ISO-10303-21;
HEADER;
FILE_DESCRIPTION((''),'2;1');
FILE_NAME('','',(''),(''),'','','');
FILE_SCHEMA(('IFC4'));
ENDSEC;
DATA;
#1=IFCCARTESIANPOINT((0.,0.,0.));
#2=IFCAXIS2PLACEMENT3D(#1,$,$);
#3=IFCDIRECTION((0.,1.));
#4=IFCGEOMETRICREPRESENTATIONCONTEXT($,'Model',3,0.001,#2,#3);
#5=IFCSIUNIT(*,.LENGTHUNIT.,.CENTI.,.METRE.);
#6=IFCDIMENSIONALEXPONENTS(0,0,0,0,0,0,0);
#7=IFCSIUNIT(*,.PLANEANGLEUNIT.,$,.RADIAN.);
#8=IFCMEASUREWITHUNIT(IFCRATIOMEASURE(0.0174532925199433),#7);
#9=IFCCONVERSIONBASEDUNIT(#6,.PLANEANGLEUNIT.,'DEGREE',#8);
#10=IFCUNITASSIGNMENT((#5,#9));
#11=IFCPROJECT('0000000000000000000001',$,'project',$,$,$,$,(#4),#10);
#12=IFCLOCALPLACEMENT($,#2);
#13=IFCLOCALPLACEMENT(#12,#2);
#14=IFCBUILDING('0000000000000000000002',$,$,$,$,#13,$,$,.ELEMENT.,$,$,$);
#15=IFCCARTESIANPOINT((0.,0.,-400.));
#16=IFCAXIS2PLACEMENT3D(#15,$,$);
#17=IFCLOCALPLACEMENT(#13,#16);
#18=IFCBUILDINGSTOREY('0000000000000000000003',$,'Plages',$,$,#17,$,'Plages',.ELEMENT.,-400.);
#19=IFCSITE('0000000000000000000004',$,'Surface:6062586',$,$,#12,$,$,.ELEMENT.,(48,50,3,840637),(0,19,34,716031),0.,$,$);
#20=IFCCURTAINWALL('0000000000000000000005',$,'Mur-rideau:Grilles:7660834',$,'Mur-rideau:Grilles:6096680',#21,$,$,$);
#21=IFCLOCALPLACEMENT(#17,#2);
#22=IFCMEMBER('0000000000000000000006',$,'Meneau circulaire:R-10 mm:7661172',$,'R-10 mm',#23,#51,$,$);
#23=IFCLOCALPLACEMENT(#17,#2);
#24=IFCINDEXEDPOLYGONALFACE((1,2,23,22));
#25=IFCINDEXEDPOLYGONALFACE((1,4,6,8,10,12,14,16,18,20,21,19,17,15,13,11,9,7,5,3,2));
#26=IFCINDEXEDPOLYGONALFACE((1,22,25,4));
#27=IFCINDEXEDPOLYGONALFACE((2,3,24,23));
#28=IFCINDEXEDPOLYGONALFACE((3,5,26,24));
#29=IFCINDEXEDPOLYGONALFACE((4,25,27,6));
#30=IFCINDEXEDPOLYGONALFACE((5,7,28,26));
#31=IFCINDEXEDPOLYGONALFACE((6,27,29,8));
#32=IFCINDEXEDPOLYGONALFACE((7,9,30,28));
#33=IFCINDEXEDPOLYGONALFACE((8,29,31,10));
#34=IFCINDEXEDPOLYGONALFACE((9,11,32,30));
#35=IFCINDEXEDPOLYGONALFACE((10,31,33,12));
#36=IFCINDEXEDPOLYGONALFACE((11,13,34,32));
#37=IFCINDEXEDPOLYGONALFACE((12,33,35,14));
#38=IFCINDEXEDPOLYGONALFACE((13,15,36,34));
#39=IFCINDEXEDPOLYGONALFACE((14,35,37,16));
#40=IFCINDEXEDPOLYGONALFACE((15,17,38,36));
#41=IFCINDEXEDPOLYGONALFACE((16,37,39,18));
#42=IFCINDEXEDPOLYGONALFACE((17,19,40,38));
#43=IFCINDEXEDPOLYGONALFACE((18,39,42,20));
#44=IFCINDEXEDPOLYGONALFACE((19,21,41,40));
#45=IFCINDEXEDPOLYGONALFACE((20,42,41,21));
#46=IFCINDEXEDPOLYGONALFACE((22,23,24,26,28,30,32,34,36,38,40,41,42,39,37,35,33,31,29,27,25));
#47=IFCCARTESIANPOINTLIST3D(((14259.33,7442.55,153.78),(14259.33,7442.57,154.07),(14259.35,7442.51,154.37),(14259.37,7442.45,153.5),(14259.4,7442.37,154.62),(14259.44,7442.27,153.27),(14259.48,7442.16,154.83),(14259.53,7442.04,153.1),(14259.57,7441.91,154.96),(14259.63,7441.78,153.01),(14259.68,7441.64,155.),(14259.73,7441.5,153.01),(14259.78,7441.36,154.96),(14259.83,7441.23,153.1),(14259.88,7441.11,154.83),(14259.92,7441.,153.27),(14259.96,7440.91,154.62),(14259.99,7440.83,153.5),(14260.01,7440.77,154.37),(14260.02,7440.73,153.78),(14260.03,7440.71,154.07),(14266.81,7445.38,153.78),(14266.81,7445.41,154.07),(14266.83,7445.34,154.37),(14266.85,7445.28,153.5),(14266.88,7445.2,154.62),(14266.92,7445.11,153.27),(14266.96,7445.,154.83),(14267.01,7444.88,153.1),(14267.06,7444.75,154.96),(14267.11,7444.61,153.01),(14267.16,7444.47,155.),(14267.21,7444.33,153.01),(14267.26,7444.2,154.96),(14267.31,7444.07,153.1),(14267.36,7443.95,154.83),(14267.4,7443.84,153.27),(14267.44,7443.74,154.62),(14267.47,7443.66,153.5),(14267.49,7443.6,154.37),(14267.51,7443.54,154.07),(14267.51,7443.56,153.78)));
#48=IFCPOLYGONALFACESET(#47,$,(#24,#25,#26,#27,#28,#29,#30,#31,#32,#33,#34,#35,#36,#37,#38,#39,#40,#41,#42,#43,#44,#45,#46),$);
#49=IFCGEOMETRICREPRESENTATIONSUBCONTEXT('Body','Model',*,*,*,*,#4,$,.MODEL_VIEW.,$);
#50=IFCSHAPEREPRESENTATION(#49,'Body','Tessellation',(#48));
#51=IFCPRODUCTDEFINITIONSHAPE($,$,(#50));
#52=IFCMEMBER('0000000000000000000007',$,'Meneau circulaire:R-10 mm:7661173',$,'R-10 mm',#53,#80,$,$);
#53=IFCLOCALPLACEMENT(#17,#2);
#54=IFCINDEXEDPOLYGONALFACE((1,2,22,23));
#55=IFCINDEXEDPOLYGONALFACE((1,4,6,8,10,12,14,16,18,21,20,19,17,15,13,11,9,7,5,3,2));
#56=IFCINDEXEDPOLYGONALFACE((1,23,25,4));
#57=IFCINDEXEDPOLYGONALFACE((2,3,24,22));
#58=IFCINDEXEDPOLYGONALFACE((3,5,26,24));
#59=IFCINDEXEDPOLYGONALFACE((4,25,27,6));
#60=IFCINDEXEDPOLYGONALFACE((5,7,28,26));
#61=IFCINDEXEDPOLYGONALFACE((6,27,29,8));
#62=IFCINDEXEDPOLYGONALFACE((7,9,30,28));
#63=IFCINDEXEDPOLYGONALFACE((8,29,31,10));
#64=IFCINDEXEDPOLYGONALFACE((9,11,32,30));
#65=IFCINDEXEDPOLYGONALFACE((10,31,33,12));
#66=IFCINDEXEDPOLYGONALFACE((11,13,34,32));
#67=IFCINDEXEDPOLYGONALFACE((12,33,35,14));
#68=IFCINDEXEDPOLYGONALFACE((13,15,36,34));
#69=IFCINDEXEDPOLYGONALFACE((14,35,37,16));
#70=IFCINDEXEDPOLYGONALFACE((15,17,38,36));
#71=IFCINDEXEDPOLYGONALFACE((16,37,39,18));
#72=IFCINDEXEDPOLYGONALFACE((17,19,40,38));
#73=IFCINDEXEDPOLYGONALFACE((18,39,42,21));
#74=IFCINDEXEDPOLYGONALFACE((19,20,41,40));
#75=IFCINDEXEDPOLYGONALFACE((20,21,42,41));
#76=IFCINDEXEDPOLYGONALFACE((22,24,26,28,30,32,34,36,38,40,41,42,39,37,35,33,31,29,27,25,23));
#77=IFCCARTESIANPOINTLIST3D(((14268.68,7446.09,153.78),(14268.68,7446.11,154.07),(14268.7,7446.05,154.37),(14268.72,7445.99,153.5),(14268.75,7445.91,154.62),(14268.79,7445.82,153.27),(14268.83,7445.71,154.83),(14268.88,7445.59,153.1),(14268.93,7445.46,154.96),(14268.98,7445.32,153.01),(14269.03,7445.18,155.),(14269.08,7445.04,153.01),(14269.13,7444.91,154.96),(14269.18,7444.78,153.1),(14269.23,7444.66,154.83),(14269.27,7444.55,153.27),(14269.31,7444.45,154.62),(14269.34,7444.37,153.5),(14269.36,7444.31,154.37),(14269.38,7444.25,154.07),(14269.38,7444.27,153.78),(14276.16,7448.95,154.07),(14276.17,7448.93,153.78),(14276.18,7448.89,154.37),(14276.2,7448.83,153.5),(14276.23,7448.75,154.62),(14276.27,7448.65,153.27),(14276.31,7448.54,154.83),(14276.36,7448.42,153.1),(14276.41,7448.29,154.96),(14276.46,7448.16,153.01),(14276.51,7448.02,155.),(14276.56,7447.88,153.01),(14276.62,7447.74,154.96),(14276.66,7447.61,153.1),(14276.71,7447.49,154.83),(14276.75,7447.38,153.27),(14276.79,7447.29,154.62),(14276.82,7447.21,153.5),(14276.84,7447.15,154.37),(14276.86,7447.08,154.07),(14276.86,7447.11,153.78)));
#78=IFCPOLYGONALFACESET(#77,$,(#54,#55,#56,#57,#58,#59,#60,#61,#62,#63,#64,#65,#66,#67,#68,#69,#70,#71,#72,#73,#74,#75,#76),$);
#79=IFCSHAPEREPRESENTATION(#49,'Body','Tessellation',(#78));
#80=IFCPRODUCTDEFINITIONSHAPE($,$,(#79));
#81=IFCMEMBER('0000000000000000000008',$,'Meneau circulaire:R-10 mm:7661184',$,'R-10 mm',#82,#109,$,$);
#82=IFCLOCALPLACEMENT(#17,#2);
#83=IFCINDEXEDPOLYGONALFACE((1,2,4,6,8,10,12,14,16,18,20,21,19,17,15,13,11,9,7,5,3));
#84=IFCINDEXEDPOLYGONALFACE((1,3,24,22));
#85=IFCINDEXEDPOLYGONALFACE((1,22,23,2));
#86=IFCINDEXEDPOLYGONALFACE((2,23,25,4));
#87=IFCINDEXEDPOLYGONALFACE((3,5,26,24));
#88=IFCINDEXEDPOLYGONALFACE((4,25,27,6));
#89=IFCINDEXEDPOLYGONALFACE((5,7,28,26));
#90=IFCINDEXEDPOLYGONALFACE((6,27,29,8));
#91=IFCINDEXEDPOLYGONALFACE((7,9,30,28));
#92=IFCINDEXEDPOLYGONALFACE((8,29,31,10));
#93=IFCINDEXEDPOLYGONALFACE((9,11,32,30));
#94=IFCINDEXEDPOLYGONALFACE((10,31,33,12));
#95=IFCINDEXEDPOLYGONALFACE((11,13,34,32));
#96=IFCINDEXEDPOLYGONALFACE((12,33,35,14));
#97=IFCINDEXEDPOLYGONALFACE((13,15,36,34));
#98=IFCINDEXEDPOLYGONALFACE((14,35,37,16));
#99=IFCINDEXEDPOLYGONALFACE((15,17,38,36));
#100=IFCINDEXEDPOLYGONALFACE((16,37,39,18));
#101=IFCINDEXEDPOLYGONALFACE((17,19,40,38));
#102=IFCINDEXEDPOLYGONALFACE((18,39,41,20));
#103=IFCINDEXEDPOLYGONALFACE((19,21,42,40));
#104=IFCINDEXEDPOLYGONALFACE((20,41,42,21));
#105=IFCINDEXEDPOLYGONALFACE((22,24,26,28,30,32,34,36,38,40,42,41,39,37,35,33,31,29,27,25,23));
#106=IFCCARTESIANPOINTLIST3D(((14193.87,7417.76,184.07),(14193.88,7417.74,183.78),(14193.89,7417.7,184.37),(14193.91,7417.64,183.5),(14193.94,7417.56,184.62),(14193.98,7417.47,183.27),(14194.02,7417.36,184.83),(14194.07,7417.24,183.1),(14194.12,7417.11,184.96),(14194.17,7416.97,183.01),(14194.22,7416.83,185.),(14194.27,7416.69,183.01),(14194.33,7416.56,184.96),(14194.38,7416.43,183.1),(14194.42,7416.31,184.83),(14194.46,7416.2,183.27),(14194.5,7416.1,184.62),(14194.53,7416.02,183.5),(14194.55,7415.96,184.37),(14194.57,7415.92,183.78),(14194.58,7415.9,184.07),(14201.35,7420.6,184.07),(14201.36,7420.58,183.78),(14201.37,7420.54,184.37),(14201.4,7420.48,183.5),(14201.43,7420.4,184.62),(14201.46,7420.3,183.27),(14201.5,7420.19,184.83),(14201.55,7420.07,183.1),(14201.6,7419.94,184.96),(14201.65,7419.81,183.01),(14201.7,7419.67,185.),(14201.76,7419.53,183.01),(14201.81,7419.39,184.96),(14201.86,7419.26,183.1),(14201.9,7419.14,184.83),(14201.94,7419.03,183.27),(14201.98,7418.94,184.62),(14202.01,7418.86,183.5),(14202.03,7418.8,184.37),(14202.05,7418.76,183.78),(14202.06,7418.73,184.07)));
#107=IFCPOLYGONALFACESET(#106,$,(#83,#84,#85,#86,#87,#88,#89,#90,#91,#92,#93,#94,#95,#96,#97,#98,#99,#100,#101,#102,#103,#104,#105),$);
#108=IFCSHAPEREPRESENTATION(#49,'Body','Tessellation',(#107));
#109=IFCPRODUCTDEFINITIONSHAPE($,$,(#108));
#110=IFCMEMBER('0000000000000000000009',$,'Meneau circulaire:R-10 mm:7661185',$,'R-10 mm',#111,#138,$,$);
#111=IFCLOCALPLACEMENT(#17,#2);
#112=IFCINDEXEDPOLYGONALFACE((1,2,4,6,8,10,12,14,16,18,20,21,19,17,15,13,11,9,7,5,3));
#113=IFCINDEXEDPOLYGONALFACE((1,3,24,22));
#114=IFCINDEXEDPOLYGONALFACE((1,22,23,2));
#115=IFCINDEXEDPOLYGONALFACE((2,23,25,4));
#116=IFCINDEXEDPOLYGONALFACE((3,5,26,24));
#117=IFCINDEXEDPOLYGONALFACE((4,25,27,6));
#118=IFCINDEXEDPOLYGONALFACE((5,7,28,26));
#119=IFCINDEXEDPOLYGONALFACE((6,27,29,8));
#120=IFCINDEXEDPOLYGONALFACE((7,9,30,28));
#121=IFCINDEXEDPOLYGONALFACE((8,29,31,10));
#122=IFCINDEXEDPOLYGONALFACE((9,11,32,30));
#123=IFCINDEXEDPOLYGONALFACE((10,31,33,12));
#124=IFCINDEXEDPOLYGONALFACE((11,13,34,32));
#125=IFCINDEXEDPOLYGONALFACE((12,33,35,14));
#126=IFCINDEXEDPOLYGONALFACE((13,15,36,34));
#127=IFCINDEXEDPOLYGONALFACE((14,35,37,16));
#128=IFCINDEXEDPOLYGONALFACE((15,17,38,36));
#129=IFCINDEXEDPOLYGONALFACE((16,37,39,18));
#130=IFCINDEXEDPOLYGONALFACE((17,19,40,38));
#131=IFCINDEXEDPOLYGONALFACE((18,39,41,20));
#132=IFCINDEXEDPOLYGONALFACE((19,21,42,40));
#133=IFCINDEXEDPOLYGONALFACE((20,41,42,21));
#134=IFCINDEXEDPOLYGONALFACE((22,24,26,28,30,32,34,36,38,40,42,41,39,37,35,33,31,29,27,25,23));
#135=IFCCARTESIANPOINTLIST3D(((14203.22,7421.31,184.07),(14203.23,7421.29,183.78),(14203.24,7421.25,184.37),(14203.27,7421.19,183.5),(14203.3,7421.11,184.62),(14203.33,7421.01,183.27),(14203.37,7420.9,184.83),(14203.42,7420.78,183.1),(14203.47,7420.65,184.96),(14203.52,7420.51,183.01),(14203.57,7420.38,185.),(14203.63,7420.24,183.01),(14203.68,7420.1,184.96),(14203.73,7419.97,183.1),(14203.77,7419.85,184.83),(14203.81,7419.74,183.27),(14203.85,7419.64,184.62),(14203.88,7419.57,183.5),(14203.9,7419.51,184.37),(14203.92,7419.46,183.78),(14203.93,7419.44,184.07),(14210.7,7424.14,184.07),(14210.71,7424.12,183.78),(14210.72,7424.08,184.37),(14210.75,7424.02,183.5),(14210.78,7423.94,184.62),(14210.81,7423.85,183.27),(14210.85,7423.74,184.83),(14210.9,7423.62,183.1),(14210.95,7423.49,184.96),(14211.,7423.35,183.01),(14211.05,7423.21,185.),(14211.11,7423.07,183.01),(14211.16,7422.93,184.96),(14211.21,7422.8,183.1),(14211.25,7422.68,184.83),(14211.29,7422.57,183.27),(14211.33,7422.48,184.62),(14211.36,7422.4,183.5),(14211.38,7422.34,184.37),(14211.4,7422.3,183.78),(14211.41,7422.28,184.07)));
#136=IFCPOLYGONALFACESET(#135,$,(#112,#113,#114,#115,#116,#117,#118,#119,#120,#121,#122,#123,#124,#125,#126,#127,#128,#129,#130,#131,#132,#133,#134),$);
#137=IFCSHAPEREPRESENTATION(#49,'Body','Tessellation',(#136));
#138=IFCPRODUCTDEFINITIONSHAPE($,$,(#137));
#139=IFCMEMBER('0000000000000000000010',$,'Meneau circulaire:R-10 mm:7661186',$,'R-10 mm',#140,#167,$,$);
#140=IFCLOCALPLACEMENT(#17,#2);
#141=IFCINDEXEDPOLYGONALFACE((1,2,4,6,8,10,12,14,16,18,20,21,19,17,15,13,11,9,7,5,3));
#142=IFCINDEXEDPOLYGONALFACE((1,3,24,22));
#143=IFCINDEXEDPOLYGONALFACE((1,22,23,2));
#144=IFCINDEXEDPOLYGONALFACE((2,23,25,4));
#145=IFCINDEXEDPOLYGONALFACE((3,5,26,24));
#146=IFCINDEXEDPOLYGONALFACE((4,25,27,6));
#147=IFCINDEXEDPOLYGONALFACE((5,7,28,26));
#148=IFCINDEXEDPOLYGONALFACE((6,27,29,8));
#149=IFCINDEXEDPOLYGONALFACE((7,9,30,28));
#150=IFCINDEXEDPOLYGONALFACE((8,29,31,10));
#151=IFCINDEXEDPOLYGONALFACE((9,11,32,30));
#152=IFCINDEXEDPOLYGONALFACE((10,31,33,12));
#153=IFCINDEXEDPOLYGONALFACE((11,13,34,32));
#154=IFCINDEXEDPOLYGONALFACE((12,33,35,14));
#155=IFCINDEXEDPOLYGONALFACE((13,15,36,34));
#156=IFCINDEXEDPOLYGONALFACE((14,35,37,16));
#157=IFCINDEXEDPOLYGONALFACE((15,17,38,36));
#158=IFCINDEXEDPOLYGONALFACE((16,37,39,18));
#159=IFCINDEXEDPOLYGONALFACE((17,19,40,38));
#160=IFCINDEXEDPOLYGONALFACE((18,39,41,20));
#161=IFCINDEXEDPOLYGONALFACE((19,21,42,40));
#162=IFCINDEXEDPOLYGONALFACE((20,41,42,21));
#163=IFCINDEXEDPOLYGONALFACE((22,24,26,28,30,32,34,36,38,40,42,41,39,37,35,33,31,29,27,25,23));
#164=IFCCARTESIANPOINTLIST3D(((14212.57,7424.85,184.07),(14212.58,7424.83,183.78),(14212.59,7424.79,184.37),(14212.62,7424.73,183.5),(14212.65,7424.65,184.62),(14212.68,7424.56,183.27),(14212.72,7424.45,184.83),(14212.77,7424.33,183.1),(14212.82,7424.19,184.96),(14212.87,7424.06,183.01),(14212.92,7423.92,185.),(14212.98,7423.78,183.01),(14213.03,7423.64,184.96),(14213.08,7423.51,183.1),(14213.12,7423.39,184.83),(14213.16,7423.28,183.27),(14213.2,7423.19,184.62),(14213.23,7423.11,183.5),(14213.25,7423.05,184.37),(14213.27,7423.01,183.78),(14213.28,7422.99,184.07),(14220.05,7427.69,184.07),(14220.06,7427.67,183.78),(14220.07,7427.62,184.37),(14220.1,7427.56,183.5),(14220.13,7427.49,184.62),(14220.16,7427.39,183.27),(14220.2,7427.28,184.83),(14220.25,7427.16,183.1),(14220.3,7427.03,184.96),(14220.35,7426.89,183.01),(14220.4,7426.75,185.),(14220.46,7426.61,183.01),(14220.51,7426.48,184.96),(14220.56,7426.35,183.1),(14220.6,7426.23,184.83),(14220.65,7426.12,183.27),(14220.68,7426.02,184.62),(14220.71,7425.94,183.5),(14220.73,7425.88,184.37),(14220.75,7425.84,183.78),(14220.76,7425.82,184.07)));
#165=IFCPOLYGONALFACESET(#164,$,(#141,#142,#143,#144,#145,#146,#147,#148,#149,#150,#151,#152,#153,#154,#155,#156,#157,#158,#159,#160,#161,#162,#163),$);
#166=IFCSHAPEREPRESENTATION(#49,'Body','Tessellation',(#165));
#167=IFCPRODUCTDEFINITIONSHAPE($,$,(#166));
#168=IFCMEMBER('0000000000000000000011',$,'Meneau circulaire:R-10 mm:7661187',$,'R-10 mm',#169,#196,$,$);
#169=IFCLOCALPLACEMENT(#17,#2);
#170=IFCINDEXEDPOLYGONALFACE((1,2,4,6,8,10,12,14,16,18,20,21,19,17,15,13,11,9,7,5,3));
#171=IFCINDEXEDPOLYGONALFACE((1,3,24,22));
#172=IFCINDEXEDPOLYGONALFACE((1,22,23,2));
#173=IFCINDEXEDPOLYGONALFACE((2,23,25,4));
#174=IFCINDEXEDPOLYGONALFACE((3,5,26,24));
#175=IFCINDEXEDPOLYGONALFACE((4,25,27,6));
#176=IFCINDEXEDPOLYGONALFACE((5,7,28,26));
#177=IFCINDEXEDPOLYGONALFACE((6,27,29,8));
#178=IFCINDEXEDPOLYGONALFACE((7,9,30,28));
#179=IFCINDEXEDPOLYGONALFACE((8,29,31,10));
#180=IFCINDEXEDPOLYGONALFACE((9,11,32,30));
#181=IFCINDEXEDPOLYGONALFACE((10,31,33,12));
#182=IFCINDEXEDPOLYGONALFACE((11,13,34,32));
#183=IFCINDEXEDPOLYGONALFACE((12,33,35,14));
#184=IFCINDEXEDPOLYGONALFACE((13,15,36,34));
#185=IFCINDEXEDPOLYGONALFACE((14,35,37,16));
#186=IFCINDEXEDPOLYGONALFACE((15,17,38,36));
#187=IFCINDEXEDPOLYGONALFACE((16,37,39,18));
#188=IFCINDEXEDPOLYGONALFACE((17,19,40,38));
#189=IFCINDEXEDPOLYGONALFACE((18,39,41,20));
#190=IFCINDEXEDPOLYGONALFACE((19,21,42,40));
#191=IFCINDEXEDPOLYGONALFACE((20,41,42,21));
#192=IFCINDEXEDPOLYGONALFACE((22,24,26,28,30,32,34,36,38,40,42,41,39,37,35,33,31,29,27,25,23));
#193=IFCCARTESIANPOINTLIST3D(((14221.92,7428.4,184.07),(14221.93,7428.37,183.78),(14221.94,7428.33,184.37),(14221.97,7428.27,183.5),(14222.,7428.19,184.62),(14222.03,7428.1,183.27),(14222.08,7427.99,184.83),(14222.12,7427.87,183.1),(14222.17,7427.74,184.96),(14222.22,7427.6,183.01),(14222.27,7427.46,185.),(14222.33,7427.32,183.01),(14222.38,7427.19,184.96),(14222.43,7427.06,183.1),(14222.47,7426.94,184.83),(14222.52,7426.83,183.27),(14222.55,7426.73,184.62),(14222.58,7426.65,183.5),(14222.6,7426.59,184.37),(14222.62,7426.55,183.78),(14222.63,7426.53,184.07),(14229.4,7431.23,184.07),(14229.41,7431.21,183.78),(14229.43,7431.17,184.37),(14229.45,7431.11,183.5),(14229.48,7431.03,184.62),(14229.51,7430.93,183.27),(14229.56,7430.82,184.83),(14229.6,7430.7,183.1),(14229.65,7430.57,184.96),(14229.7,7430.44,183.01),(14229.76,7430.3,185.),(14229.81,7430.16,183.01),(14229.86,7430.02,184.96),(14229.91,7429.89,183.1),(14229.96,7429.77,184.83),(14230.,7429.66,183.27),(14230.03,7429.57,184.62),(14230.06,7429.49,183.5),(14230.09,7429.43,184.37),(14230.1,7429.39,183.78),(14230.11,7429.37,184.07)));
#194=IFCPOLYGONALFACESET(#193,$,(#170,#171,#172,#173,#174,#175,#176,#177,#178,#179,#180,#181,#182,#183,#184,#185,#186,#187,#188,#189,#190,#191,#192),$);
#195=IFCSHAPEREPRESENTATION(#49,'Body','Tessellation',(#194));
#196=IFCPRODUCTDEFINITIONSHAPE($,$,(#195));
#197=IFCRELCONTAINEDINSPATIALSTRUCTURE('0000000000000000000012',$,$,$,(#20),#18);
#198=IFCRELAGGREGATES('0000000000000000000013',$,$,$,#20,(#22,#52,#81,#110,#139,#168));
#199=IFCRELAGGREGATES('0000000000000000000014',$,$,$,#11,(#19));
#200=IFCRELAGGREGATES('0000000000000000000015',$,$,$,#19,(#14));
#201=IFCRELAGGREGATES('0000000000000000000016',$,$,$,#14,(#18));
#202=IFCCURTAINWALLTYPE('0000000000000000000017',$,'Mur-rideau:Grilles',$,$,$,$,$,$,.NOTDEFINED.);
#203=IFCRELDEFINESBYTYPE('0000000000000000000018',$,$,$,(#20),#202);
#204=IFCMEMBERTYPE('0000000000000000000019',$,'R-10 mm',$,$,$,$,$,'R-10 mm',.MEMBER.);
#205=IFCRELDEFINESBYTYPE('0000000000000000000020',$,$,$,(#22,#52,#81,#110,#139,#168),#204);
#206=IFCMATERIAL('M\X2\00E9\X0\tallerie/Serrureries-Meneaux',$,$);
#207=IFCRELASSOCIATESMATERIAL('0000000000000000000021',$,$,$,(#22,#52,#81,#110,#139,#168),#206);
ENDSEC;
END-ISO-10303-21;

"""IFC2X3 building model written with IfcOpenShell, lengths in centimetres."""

from ifc_helpers import new_model, entity, si_unit, converted_unit, direction, frame, frame_2d, origin, place, context, subcontext, project, spatial, circle, extrude, source, transform, mapped, material, type_object, type_shapes, element, aggregate, save


model = new_model("IFC2X3")

# Units and contexts
model_context = context("Model", 3, precision=0.001, world=origin(), true_north=direction((0.0, 1.0)))
body_context = subcontext(model_context, "Body", "Model", "MODEL_VIEW")
ifc_project = project(units=[si_unit("LENGTHUNIT", "METRE", prefix="CENTI"), converted_unit("PLANEANGLEUNIT", "DEGREE", entity("IfcRatioMeasure", 0.0174532925199433), si_unit("PLANEANGLEUNIT", "RADIAN"), dimensions=[0, 0, 0, 0, 0, 0, 0])], contexts=[model_context])

# Site, building, storey
site_placement = place(None, origin())
site = spatial("IfcSite", under=ifc_project, at=site_placement, Name="Surface:6062586", CompositionType="ELEMENT", RefLatitude=(48, 50, 3, 840637), RefLongitude=(0, 19, 34, 716031), RefElevation=0.0)
building_placement = place(site_placement, origin())
building = spatial("IfcBuilding", under=site, at=building_placement, CompositionType="ELEMENT")
storey_placement = place(building_placement, frame((0.0, 0.0, -400.0)))
storey = spatial("IfcBuildingStorey", under=building, at=storey_placement, Name="Plages", LongName="Plages", CompositionType="ELEMENT", Elevation=-400.0)

# Curtain wall, members
curtain_wall_type = type_object("IfcCurtainWallType", Name="Mur-rideau:Grilles", PredefinedType="NOTDEFINED")
curtain_wall_placement = place(storey_placement, frame((0.0, 0.0, 400.0)))
curtain_wall = element("IfcCurtainWall", 1, at=curtain_wall_placement, inside=storey, type_object=curtain_wall_type, Name="Mur-rideau:Grilles:7660834", ObjectType="Mur-rideau:Grilles:6096680")
ifc_material = material(Name="Métallerie/Serrureries-Meneaux")
member_type_1 = type_object("IfcMemberType", Name="R-10 mm", ElementType="R-10 mm", PredefinedType="MEMBER")
shared_shape_1 = source(origin(), body_context, "Body", "SweptSolid", [
    extrude(circle(Radius=1.0, at=frame_2d((0.0, 0.0), x_axis=(1.0, 0.0))), frame((0.0, 0.0, -8.0)), (0.0, 0.0, 1.0), 8.0),
])
type_shapes(member_type_1, [shared_shape_1])
member_1_placement = place(storey_placement, frame((14267.16, 7444.47, 154.0), z_axis=(0.935103, 0.354376, 0.0), x_axis=(0.0, 0.0, 1.0)))
member_1 = element("IfcMember", 2, at=member_1_placement, type_object=member_type_1, material=ifc_material, Name="Meneau circulaire:R-10 mm:7661172", ObjectType="R-10 mm", context=body_context, shape_type="MappedRepresentation", body=[
    mapped(shared_shape_1, transform((0.0, 0.0, 0.0), scale=1.0)),
])
member_2_placement = place(storey_placement, frame((14276.51, 7448.02, 154.0), z_axis=(0.935103, 0.354376, 0.0), x_axis=(0.0, 0.0, 1.0)))
member_2 = element("IfcMember", 3, at=member_2_placement, type_object=member_type_1, material=ifc_material, Name="Meneau circulaire:R-10 mm:7661173", ObjectType="R-10 mm", context=body_context, shape_type="MappedRepresentation", body=[
    mapped(shared_shape_1, transform((0.0, 0.0, 0.0), scale=1.0)),
])
member_3_placement = place(storey_placement, frame((14201.7, 7419.67, 184.0), z_axis=(0.935103, 0.354376, 0.0), x_axis=(0.0, 0.0, 1.0)))
member_3 = element("IfcMember", 4, at=member_3_placement, type_object=member_type_1, material=ifc_material, Name="Meneau circulaire:R-10 mm:7661184", ObjectType="R-10 mm", context=body_context, shape_type="MappedRepresentation", body=[
    mapped(shared_shape_1, transform((0.0, 0.0, 0.0), scale=1.0)),
])
member_4_placement = place(storey_placement, frame((14211.05, 7423.21, 184.0), z_axis=(0.935103, 0.354376, 0.0), x_axis=(0.0, 0.0, 1.0)))
member_4 = element("IfcMember", 5, at=member_4_placement, type_object=member_type_1, material=ifc_material, Name="Meneau circulaire:R-10 mm:7661185", ObjectType="R-10 mm", context=body_context, shape_type="MappedRepresentation", body=[
    mapped(shared_shape_1, transform((0.0, 0.0, 0.0), scale=1.0)),
])
member_5_placement = place(storey_placement, frame((14220.4, 7426.75, 184.0), z_axis=(0.935103, 0.354376, 0.0), x_axis=(0.0, 0.0, 1.0)))
member_5 = element("IfcMember", 6, at=member_5_placement, type_object=member_type_1, material=ifc_material, Name="Meneau circulaire:R-10 mm:7661186", ObjectType="R-10 mm", context=body_context, shape_type="MappedRepresentation", body=[
    mapped(shared_shape_1, transform((0.0, 0.0, 0.0), scale=1.0)),
])
member_6_placement = place(storey_placement, frame((14229.76, 7430.3, 184.0), z_axis=(0.935103, 0.354376, 0.0), x_axis=(0.0, 0.0, 1.0)))
member_6 = element("IfcMember", 7, at=member_6_placement, type_object=member_type_1, material=ifc_material, Name="Meneau circulaire:R-10 mm:7661187", ObjectType="R-10 mm", context=body_context, shape_type="MappedRepresentation", body=[
    mapped(shared_shape_1, transform((0.0, 0.0, 0.0), scale=1.0)),
])
aggregate(curtain_wall, [member_1, member_2, member_3, member_4, member_5, member_6])

save(model, "model.ifc")
